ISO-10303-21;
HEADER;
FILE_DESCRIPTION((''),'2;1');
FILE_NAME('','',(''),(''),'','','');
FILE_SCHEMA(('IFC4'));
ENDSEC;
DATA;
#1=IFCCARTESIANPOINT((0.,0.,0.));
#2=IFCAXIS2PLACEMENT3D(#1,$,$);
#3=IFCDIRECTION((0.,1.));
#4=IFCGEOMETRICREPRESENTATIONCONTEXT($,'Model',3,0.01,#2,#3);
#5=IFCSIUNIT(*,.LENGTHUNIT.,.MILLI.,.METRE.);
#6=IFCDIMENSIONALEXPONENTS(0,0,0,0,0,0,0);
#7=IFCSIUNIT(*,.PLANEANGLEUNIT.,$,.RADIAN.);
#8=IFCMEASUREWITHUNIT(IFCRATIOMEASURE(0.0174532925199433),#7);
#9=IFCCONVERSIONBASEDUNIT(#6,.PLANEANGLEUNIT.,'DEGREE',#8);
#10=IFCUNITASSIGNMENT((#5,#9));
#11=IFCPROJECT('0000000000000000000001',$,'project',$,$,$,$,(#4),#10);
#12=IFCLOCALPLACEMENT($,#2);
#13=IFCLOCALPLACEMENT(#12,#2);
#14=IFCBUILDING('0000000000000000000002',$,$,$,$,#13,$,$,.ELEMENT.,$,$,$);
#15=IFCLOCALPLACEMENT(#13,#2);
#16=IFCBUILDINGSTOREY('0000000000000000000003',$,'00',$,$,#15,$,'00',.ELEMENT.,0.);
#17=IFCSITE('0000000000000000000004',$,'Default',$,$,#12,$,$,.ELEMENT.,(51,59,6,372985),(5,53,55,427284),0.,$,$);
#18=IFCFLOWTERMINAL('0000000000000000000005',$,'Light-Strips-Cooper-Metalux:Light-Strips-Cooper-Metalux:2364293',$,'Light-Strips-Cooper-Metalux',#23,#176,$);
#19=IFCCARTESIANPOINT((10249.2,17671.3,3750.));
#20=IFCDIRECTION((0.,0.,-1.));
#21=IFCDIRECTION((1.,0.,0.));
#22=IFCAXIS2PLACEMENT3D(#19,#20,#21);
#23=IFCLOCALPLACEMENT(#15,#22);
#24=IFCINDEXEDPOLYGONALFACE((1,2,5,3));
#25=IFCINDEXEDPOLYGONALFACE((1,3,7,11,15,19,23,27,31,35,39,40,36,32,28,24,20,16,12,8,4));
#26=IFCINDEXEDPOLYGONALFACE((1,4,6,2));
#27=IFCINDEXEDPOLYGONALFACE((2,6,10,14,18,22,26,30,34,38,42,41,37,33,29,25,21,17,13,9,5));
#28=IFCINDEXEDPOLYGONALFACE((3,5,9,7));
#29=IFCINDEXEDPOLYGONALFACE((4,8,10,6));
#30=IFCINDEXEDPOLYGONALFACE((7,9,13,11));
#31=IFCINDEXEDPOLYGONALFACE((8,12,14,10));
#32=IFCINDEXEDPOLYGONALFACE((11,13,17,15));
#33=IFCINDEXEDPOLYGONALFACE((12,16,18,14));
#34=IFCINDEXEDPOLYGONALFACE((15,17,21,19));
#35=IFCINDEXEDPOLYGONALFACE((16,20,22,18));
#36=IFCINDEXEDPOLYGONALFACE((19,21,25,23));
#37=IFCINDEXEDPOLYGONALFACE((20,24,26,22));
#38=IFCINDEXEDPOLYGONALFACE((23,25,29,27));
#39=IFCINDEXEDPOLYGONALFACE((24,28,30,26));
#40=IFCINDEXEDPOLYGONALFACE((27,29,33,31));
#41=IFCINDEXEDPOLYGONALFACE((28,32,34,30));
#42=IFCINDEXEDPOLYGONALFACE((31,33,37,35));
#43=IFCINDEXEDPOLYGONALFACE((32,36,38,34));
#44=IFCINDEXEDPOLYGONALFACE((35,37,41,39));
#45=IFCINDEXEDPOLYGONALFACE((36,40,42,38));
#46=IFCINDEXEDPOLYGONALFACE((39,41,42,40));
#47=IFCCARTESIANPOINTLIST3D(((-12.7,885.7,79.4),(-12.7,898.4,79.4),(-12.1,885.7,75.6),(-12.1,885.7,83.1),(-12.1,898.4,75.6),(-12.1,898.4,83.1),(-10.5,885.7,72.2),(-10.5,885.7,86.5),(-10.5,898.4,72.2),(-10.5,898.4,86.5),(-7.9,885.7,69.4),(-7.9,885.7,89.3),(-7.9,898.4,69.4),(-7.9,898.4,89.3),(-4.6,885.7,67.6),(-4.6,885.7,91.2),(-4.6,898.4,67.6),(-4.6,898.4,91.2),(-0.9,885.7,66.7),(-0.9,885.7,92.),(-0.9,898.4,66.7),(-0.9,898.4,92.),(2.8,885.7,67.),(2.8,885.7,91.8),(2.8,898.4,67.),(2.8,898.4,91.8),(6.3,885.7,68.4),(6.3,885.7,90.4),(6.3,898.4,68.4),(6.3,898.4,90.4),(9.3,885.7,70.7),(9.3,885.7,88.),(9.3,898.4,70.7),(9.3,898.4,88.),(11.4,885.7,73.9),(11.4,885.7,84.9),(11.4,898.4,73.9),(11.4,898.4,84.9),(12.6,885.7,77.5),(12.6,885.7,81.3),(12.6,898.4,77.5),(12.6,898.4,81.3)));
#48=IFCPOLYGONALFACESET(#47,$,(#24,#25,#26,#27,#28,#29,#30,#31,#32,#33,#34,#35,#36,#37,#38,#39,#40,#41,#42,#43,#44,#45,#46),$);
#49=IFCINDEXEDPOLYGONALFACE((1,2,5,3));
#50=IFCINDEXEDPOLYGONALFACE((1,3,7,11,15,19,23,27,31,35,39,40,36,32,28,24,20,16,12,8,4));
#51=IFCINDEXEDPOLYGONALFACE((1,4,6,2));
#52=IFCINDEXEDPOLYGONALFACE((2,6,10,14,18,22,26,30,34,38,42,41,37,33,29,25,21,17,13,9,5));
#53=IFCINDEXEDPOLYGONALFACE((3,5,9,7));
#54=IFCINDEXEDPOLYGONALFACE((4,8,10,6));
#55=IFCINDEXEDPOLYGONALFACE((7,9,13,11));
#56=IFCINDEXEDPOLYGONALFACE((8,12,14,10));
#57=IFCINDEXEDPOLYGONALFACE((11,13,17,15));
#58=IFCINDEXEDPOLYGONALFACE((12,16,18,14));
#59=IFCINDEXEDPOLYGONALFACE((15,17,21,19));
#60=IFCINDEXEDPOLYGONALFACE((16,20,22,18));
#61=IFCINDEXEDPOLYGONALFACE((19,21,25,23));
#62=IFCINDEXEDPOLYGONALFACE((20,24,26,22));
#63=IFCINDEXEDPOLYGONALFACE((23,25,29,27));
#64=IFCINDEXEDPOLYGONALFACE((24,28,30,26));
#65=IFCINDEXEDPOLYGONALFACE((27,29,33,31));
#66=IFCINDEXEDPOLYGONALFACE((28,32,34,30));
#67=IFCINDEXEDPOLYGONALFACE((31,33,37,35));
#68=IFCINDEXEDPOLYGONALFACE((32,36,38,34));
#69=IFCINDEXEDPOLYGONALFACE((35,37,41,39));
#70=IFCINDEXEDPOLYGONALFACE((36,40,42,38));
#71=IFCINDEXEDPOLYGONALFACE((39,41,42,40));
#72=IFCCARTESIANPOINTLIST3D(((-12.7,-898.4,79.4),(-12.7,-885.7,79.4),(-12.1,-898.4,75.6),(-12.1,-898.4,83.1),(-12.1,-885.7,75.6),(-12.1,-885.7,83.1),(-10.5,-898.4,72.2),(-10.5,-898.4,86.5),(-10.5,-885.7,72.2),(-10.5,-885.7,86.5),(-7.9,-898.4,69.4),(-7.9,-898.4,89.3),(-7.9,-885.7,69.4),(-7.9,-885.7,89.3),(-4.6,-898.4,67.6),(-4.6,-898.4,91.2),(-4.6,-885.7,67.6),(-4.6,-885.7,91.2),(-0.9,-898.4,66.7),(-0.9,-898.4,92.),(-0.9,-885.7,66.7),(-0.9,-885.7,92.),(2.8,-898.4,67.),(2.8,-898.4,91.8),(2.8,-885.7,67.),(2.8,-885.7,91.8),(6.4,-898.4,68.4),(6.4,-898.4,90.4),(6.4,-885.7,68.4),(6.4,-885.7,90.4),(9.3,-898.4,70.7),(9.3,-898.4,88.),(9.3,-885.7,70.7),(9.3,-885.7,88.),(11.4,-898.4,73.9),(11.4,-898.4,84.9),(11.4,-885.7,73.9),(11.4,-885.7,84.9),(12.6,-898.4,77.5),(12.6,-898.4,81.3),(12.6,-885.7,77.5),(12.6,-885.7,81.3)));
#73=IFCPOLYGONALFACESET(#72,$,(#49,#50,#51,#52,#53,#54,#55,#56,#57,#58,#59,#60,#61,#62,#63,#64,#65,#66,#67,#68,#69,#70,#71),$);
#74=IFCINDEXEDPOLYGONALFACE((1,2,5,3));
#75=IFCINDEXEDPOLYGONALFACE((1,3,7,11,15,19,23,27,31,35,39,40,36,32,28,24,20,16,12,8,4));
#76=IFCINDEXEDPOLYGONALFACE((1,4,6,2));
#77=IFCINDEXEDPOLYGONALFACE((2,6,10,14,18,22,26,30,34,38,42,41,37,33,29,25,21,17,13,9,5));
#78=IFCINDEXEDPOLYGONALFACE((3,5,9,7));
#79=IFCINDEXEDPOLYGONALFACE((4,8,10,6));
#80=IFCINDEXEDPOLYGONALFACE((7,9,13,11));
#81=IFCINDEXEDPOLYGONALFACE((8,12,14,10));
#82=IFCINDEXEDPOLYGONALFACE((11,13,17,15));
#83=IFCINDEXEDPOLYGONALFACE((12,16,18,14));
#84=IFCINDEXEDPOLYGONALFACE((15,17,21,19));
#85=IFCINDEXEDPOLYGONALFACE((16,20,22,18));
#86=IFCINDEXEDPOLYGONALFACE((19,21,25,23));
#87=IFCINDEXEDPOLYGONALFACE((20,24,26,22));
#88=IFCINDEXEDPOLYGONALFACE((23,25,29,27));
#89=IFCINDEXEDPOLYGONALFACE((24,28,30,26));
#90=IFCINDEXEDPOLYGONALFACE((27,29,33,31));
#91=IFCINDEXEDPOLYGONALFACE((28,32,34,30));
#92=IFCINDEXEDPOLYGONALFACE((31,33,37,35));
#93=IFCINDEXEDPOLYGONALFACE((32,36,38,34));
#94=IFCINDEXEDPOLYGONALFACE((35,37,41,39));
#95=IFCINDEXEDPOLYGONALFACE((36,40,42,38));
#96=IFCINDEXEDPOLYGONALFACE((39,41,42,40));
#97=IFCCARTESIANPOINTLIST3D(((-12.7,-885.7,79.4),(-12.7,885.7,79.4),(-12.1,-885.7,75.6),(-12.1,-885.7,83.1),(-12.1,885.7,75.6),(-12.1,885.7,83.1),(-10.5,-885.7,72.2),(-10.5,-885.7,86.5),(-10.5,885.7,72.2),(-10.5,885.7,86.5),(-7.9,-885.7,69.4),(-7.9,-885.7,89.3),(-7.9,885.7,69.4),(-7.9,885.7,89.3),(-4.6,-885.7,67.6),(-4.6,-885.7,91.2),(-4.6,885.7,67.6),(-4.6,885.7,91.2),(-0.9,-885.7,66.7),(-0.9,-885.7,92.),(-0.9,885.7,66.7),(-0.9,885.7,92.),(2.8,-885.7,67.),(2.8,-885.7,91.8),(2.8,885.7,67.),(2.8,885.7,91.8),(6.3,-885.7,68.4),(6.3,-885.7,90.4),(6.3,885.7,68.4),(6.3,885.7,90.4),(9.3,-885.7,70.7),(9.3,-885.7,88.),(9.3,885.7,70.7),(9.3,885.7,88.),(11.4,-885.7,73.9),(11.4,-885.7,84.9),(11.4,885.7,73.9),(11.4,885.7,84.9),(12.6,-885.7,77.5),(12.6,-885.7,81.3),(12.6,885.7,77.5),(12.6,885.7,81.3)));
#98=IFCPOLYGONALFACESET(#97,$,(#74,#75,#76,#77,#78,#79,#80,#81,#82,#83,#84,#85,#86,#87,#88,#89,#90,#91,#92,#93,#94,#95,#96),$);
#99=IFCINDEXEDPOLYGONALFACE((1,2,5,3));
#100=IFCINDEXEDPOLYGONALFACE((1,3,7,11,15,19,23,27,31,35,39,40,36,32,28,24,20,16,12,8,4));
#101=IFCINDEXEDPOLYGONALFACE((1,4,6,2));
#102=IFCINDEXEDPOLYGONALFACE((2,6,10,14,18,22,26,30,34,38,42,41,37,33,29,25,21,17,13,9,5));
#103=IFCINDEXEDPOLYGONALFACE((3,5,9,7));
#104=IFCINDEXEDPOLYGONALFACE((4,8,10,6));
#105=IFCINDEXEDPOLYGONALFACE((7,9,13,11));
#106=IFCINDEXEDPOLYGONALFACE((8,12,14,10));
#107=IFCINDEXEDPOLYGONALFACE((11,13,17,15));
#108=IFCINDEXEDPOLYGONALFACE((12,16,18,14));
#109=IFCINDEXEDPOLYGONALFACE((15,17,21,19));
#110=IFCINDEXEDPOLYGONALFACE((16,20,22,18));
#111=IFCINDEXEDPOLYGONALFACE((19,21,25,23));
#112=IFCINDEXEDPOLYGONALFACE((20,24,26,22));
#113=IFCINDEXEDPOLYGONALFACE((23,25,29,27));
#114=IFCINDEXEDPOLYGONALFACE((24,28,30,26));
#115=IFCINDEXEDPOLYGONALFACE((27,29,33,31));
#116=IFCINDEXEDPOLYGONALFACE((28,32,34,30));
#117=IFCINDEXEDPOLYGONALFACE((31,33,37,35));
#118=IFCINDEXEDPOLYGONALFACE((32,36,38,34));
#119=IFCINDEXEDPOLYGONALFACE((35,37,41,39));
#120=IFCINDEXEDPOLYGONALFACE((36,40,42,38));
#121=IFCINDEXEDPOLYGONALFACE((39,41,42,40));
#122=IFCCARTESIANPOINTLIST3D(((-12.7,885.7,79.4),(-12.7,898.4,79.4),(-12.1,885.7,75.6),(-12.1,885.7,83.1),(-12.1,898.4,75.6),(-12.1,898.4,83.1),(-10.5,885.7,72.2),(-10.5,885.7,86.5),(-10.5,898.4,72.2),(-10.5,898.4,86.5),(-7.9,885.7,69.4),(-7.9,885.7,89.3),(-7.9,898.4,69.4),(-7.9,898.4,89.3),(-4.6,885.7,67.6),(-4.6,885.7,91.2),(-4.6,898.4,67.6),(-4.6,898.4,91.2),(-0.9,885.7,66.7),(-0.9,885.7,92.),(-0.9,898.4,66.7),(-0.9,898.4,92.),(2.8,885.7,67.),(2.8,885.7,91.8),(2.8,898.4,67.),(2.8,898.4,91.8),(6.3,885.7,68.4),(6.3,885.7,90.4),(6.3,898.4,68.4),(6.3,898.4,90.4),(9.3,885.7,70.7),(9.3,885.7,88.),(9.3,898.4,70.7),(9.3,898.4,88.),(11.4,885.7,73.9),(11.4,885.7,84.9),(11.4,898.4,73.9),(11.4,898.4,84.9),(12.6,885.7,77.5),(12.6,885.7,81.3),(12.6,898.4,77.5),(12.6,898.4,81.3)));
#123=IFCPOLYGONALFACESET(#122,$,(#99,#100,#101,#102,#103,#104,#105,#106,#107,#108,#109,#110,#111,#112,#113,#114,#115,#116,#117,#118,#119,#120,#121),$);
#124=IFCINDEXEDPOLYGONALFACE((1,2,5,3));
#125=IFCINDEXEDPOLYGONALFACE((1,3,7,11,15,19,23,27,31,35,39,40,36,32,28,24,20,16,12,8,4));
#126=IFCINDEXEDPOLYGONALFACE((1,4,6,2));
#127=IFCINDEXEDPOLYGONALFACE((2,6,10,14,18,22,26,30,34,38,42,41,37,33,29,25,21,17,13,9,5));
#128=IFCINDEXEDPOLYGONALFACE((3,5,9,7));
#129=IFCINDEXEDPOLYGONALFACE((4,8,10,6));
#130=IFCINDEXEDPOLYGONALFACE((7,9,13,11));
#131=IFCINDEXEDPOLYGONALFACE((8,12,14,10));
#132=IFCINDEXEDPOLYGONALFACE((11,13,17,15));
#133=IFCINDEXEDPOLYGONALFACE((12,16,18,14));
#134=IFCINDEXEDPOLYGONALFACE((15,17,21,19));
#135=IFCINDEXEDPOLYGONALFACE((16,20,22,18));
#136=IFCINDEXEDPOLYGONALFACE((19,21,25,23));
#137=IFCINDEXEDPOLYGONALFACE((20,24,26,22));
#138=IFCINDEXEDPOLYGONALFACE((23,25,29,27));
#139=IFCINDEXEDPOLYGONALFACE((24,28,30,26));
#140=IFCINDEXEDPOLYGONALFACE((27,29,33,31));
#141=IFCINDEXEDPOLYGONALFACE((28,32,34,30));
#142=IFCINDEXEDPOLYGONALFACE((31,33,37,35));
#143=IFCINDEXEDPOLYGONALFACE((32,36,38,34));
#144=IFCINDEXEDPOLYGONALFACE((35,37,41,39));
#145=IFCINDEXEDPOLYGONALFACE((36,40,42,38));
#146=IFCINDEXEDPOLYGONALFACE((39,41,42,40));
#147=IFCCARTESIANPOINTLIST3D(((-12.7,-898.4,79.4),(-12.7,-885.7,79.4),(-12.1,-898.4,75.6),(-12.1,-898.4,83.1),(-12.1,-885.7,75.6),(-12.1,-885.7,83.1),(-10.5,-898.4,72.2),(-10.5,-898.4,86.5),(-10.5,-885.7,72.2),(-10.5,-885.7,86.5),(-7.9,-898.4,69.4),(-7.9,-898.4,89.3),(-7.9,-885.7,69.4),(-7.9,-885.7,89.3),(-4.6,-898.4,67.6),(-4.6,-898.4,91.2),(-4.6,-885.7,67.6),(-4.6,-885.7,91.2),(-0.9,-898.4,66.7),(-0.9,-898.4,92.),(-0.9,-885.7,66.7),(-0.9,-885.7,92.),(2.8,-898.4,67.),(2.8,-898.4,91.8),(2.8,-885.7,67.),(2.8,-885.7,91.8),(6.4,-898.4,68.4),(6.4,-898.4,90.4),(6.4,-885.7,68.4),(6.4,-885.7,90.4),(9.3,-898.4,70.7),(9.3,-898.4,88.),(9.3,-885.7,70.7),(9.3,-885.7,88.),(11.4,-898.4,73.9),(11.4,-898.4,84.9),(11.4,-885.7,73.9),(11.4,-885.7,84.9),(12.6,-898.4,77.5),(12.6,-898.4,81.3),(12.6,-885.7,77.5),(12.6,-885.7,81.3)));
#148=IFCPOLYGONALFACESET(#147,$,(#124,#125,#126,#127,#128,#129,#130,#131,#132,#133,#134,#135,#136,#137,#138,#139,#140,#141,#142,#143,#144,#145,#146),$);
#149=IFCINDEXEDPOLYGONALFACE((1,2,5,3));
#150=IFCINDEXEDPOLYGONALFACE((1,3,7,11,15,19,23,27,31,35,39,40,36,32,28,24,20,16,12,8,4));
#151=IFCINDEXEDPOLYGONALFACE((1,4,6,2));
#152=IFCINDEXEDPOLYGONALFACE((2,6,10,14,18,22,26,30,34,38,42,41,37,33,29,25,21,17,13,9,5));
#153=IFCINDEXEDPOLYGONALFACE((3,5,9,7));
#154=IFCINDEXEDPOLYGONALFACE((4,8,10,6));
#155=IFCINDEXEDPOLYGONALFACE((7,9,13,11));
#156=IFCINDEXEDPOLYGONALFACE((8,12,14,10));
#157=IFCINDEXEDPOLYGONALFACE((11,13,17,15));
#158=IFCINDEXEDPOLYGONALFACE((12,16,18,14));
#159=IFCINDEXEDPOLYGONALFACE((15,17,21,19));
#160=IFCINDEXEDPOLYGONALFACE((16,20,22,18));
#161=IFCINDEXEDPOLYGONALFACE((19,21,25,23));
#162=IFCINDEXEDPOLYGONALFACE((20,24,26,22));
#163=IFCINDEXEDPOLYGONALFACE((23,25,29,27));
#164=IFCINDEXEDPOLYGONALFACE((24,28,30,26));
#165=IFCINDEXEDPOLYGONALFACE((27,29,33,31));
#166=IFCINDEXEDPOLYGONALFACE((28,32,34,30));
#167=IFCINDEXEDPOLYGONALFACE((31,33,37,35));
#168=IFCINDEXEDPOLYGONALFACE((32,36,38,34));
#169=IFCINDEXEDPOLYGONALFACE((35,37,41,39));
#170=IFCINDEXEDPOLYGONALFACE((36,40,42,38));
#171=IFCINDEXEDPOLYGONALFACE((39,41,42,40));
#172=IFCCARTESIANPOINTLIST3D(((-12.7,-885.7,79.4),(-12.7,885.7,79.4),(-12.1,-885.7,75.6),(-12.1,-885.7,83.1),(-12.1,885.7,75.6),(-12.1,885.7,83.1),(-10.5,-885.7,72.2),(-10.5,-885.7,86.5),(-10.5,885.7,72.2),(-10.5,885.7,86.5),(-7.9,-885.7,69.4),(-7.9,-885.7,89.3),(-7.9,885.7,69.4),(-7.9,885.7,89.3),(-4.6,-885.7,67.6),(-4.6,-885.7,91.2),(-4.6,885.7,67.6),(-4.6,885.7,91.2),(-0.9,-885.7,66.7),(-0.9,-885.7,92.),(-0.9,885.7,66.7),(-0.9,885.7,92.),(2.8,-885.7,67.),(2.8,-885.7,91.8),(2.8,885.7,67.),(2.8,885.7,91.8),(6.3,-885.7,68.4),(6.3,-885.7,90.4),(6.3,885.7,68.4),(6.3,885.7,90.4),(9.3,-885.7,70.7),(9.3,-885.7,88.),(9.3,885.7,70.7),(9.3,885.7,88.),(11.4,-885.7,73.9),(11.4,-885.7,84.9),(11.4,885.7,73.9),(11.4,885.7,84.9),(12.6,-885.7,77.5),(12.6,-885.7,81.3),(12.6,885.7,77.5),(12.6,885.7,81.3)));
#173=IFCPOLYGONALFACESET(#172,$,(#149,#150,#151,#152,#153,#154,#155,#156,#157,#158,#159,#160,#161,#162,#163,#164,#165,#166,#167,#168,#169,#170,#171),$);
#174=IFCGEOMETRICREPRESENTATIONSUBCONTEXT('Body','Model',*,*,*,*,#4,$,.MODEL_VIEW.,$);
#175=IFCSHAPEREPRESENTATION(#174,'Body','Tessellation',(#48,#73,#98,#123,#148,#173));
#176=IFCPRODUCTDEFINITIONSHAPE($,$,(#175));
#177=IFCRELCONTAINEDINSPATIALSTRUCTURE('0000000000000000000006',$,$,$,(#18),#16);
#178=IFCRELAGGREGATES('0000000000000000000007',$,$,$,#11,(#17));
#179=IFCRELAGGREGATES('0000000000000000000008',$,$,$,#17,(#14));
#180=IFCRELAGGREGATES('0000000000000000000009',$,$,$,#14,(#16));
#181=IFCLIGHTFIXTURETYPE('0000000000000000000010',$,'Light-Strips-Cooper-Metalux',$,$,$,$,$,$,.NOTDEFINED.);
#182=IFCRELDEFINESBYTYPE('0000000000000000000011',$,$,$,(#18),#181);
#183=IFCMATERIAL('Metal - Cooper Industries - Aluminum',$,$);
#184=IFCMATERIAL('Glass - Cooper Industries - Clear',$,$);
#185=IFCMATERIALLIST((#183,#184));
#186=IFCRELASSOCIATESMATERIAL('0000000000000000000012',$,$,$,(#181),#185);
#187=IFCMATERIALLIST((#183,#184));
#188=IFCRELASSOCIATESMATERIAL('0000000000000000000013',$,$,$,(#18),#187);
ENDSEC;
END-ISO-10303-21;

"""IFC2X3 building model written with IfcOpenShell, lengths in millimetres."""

from ifc_helpers import new_model, entity, si_unit, converted_unit, direction, frame, frame_2d, origin, place, context, subcontext, project, spatial, circle, extrude, source, transform, mapped, material, material_list, type_object, type_shapes, element, save


model = new_model("IFC2X3")

# Units and contexts
model_context = context("Model", 3, precision=0.01, world=origin(), true_north=direction((0.0, 1.0)))
body_context = subcontext(model_context, "Body", "Model", "MODEL_VIEW")
ifc_project = project(units=[si_unit("LENGTHUNIT", "METRE", prefix="MILLI"), converted_unit("PLANEANGLEUNIT", "DEGREE", entity("IfcRatioMeasure", 0.0174532925199433), si_unit("PLANEANGLEUNIT", "RADIAN"), dimensions=[0, 0, 0, 0, 0, 0, 0])], contexts=[model_context])

# Site, building, storey
site_placement = place(None, origin())
site = spatial("IfcSite", under=ifc_project, at=site_placement, Name="Default", CompositionType="ELEMENT", RefLatitude=(51, 59, 6, 372985), RefLongitude=(5, 53, 55, 427284), RefElevation=0.0)
building_placement = place(site_placement, origin())
building = spatial("IfcBuilding", under=site, at=building_placement, CompositionType="ELEMENT")
storey_placement = place(building_placement, origin())
storey = spatial("IfcBuildingStorey", under=building, at=storey_placement, Name="00", LongName="00", CompositionType="ELEMENT", Elevation=0.0)

# Flow terminal
ifc_material_1 = material(Name="Metal - Cooper Industries - Aluminum")
ifc_material_2 = material(Name="Glass - Cooper Industries - Clear")
ifc_material_list_1 = material_list([ifc_material_1, ifc_material_2])
light_fixture_type_1 = type_object("IfcLightFixtureType", Name="Light-Strips-Cooper-Metalux", PredefinedType="NOTDEFINED", material=ifc_material_list_1)
shared_shape_1 = source(origin(), body_context, "Body", "SweptSolid", [
    extrude(circle(Radius=12.7, at=frame_2d((0.0, 0.0), x_axis=(1.0, 0.0))), frame((0.0, 885.7, 79.4), z_axis=(0.0, 1.0, 0.0), x_axis=(-1.0, 0.0, 0.0)), (0.0, 0.0, 1.0), 12.7),
    extrude(circle(Radius=12.7, at=frame_2d((0.0, 0.0), x_axis=(1.0, 0.0))), frame((0.0, -898.4, 79.4), z_axis=(0.0, 1.0, 0.0), x_axis=(-1.0, 0.0, 0.0)), (0.0, 0.0, 1.0), 12.7),
    extrude(circle(Radius=12.7, at=frame_2d((0.0, 0.0), x_axis=(1.0, 0.0))), frame((0.0, -885.7, 79.4), z_axis=(0.0, 1.0, 0.0), x_axis=(-1.0, 0.0, 0.0)), (0.0, 0.0, 1.0), 1771.4),
    extrude(circle(Radius=12.7, at=frame_2d((0.0, 0.0), x_axis=(1.0, 0.0))), frame((0.0, 885.7, 79.4), z_axis=(0.0, 1.0, 0.0), x_axis=(-1.0, 0.0, 0.0)), (0.0, 0.0, 1.0), 12.7),
    extrude(circle(Radius=12.7, at=frame_2d((0.0, 0.0), x_axis=(1.0, 0.0))), frame((0.0, -898.4, 79.4), z_axis=(0.0, 1.0, 0.0), x_axis=(-1.0, 0.0, 0.0)), (0.0, 0.0, 1.0), 12.7),
    extrude(circle(Radius=12.7, at=frame_2d((0.0, 0.0), x_axis=(1.0, 0.0))), frame((0.0, -885.7, 79.4), z_axis=(0.0, 1.0, 0.0), x_axis=(-1.0, 0.0, 0.0)), (0.0, 0.0, 1.0), 1771.4),
])
type_shapes(light_fixture_type_1, [shared_shape_1])
ifc_material_list_2 = material_list([ifc_material_1, ifc_material_2])
flow_terminal_1_placement = place(storey_placement, frame((10249.2, 17671.3, 3750.0), z_axis=(0.0, 0.0, -1.0), x_axis=(1.0, 0.0, 0.0)))
element("IfcFlowTerminal", 1, at=flow_terminal_1_placement, inside=storey, type_object=light_fixture_type_1, material=ifc_material_list_2, Name="Light-Strips-Cooper-Metalux:Light-Strips-Cooper-Metalux:2364293", ObjectType="Light-Strips-Cooper-Metalux", context=body_context, shape_type="MappedRepresentation", body=[
    mapped(shared_shape_1, transform((0.0, 0.0, 0.0), scale=1.0)),
])

save(model, "model.ifc")
